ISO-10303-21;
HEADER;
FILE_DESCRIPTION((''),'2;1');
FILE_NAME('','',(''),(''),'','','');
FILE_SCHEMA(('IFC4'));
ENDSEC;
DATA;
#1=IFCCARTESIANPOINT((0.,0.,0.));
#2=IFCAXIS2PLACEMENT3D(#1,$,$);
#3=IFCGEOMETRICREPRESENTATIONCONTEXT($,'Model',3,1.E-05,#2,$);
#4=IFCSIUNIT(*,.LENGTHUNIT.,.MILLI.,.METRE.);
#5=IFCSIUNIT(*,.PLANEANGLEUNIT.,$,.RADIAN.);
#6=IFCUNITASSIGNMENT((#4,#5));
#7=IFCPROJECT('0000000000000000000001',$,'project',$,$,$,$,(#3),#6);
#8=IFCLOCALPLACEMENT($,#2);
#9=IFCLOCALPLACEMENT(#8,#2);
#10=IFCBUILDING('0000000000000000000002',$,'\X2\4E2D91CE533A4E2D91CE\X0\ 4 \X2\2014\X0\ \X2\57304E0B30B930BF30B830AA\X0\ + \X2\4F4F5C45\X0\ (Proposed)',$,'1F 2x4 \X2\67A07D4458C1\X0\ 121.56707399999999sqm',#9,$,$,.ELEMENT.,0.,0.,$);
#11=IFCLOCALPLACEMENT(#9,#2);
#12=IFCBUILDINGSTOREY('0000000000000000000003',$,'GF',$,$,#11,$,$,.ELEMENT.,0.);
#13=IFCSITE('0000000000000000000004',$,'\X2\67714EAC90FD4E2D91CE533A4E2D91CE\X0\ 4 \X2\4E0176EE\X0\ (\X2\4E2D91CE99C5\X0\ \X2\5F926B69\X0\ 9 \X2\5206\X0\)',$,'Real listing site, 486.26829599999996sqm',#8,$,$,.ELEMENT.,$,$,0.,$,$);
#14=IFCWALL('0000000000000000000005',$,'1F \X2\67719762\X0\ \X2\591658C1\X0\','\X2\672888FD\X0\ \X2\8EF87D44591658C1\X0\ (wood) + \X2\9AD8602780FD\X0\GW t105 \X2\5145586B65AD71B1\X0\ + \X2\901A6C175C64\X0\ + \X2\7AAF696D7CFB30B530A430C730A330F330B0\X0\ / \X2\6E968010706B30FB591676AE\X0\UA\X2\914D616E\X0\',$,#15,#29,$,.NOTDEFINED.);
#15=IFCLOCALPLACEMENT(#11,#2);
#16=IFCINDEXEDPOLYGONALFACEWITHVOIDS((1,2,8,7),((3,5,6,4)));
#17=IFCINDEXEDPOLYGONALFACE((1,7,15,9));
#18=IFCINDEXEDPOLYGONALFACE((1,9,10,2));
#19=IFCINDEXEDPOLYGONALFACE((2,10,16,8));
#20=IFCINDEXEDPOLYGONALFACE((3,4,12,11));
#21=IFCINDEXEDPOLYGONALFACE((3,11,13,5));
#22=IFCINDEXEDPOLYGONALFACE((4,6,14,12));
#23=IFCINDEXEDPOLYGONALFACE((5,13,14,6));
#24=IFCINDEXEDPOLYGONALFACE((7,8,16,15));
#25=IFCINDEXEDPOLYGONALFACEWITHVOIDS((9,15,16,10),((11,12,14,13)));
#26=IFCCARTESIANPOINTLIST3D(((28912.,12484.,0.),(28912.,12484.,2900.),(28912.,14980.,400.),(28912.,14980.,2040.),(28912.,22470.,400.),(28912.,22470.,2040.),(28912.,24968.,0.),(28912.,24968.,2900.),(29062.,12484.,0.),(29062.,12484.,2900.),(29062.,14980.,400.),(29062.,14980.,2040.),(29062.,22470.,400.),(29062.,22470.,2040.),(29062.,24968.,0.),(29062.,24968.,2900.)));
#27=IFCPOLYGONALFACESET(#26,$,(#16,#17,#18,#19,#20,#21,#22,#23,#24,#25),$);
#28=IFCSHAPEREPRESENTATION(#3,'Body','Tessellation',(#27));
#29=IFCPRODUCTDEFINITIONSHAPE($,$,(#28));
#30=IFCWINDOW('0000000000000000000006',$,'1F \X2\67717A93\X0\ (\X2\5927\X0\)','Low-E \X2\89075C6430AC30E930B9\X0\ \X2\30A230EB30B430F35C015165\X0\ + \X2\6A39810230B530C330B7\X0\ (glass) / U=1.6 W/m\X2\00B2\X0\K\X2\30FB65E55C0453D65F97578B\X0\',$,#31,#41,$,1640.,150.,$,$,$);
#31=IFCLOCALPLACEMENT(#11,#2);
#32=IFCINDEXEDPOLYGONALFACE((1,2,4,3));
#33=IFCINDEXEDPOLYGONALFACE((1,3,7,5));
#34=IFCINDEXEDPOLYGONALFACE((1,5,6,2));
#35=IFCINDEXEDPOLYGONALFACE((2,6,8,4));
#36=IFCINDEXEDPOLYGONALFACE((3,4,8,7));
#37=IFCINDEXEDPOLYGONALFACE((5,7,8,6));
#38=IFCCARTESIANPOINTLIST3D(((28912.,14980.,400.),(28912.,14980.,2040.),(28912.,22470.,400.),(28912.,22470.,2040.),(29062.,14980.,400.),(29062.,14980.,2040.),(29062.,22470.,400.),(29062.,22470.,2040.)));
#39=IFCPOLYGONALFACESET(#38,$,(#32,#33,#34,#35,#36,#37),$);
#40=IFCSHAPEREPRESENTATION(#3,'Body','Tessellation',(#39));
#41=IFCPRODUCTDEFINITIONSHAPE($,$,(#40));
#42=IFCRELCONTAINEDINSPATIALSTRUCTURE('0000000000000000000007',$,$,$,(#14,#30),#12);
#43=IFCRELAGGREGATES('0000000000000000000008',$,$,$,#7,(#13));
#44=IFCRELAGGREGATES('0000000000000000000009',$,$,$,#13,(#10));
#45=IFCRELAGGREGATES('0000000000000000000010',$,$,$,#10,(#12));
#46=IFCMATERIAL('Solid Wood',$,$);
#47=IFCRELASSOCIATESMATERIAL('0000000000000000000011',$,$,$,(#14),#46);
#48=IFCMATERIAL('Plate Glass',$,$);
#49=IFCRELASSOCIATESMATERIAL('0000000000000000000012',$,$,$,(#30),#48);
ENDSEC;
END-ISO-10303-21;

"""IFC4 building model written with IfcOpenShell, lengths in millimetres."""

from ifc_helpers import new_model, si_unit, frame, frame_2d, origin, place, context, project, spatial, rectangle, extrude, material, element, fill, save


model = new_model("IFC4")

# Units and contexts
model_context = context("Model", 3, precision=1e-05, world=origin())
ifc_project = project(units=[si_unit("LENGTHUNIT", "METRE", prefix="MILLI"), si_unit("PLANEANGLEUNIT", "RADIAN")], contexts=[model_context])

# Site, building, storey
site_placement = place(None, origin())
site = spatial("IfcSite", under=ifc_project, at=site_placement, Name="東京都中野区中野 4 丁目 (中野駅 徒歩 9 分)", ObjectType="Real listing site, 486.26829599999996sqm", CompositionType="ELEMENT", RefElevation=0.0)
building_placement = place(site_placement, origin())
building = spatial("IfcBuilding", under=site, at=building_placement, Name="中野区中野 4 — 地下スタジオ + 住居 (Proposed)", ObjectType="1F 2x4 枠組壁 121.56707399999999sqm", CompositionType="ELEMENT", ElevationOfRefHeight=0.0, ElevationOfTerrain=0.0)
storey_placement = place(building_placement, origin())
storey = spatial("IfcBuildingStorey", under=building, at=storey_placement, Name="GF", CompositionType="ELEMENT", Elevation=0.0)

# Shared definitions
ifc_material_1 = material(Name="Solid Wood")

# Shared definitions
ifc_material_2 = material(Name="Plate Glass")

# Wall, opening, window
wall_1_placement = place(storey_placement, frame((14456.0, 6242.0, 0.0)))
wall_1 = element("IfcWall", 1, at=wall_1_placement, inside=storey, material=ifc_material_1, Name="1F 東面 外壁", Description="木製 軸組外壁 (wood) + 高性能GW t105 充填断熱 + 通気層 + 窯業系サイディング / 準耐火・外皮UA配慮", PredefinedType="NOTDEFINED", context=model_context, shape_type="SweptSolid", body=[
    extrude(rectangle(XDim=150.0, YDim=12484.0, at=frame_2d((75.0, 6242.0))), frame((14456.0, 6242.0, 0.0)), (0.0, 0.0, 1.0), 2900.0),
])
opening_1_placement = place(storey_placement, frame((14456.0, 7490.0, 200.0)))
opening_1 = element("IfcOpeningElement", 2, at=opening_1_placement, cuts=wall_1, PredefinedType="NOTDEFINED", context=model_context, shape_type="SweptSolid", body=[
    extrude(rectangle(XDim=150.0, YDim=7490.0, at=frame_2d((75.0, 3745.0))), frame((14456.0, 7490.0, 200.0)), (0.0, 0.0, 1.0), 1640.0),
])
window_1_placement = place(storey_placement, frame((14456.0, 7490.0, 200.0)))
window_1 = element("IfcWindow", 3, at=window_1_placement, inside=storey, material=ifc_material_2, Name="1F 東窓 (大)", Description="Low-E 複層ガラス アルゴン封入 + 樹脂サッシ (glass) / U=1.6 W/m²K・日射取得型", OverallHeight=1640.0, OverallWidth=150.0, context=model_context, shape_type="SweptSolid", body=[
    extrude(rectangle(XDim=150.0, YDim=7490.0, at=frame_2d((75.0, 3745.0))), frame((14456.0, 7490.0, 200.0)), (0.0, 0.0, 1.0), 1640.0),
])
fill(opening_1, window_1)

save(model, "model.ifc")
